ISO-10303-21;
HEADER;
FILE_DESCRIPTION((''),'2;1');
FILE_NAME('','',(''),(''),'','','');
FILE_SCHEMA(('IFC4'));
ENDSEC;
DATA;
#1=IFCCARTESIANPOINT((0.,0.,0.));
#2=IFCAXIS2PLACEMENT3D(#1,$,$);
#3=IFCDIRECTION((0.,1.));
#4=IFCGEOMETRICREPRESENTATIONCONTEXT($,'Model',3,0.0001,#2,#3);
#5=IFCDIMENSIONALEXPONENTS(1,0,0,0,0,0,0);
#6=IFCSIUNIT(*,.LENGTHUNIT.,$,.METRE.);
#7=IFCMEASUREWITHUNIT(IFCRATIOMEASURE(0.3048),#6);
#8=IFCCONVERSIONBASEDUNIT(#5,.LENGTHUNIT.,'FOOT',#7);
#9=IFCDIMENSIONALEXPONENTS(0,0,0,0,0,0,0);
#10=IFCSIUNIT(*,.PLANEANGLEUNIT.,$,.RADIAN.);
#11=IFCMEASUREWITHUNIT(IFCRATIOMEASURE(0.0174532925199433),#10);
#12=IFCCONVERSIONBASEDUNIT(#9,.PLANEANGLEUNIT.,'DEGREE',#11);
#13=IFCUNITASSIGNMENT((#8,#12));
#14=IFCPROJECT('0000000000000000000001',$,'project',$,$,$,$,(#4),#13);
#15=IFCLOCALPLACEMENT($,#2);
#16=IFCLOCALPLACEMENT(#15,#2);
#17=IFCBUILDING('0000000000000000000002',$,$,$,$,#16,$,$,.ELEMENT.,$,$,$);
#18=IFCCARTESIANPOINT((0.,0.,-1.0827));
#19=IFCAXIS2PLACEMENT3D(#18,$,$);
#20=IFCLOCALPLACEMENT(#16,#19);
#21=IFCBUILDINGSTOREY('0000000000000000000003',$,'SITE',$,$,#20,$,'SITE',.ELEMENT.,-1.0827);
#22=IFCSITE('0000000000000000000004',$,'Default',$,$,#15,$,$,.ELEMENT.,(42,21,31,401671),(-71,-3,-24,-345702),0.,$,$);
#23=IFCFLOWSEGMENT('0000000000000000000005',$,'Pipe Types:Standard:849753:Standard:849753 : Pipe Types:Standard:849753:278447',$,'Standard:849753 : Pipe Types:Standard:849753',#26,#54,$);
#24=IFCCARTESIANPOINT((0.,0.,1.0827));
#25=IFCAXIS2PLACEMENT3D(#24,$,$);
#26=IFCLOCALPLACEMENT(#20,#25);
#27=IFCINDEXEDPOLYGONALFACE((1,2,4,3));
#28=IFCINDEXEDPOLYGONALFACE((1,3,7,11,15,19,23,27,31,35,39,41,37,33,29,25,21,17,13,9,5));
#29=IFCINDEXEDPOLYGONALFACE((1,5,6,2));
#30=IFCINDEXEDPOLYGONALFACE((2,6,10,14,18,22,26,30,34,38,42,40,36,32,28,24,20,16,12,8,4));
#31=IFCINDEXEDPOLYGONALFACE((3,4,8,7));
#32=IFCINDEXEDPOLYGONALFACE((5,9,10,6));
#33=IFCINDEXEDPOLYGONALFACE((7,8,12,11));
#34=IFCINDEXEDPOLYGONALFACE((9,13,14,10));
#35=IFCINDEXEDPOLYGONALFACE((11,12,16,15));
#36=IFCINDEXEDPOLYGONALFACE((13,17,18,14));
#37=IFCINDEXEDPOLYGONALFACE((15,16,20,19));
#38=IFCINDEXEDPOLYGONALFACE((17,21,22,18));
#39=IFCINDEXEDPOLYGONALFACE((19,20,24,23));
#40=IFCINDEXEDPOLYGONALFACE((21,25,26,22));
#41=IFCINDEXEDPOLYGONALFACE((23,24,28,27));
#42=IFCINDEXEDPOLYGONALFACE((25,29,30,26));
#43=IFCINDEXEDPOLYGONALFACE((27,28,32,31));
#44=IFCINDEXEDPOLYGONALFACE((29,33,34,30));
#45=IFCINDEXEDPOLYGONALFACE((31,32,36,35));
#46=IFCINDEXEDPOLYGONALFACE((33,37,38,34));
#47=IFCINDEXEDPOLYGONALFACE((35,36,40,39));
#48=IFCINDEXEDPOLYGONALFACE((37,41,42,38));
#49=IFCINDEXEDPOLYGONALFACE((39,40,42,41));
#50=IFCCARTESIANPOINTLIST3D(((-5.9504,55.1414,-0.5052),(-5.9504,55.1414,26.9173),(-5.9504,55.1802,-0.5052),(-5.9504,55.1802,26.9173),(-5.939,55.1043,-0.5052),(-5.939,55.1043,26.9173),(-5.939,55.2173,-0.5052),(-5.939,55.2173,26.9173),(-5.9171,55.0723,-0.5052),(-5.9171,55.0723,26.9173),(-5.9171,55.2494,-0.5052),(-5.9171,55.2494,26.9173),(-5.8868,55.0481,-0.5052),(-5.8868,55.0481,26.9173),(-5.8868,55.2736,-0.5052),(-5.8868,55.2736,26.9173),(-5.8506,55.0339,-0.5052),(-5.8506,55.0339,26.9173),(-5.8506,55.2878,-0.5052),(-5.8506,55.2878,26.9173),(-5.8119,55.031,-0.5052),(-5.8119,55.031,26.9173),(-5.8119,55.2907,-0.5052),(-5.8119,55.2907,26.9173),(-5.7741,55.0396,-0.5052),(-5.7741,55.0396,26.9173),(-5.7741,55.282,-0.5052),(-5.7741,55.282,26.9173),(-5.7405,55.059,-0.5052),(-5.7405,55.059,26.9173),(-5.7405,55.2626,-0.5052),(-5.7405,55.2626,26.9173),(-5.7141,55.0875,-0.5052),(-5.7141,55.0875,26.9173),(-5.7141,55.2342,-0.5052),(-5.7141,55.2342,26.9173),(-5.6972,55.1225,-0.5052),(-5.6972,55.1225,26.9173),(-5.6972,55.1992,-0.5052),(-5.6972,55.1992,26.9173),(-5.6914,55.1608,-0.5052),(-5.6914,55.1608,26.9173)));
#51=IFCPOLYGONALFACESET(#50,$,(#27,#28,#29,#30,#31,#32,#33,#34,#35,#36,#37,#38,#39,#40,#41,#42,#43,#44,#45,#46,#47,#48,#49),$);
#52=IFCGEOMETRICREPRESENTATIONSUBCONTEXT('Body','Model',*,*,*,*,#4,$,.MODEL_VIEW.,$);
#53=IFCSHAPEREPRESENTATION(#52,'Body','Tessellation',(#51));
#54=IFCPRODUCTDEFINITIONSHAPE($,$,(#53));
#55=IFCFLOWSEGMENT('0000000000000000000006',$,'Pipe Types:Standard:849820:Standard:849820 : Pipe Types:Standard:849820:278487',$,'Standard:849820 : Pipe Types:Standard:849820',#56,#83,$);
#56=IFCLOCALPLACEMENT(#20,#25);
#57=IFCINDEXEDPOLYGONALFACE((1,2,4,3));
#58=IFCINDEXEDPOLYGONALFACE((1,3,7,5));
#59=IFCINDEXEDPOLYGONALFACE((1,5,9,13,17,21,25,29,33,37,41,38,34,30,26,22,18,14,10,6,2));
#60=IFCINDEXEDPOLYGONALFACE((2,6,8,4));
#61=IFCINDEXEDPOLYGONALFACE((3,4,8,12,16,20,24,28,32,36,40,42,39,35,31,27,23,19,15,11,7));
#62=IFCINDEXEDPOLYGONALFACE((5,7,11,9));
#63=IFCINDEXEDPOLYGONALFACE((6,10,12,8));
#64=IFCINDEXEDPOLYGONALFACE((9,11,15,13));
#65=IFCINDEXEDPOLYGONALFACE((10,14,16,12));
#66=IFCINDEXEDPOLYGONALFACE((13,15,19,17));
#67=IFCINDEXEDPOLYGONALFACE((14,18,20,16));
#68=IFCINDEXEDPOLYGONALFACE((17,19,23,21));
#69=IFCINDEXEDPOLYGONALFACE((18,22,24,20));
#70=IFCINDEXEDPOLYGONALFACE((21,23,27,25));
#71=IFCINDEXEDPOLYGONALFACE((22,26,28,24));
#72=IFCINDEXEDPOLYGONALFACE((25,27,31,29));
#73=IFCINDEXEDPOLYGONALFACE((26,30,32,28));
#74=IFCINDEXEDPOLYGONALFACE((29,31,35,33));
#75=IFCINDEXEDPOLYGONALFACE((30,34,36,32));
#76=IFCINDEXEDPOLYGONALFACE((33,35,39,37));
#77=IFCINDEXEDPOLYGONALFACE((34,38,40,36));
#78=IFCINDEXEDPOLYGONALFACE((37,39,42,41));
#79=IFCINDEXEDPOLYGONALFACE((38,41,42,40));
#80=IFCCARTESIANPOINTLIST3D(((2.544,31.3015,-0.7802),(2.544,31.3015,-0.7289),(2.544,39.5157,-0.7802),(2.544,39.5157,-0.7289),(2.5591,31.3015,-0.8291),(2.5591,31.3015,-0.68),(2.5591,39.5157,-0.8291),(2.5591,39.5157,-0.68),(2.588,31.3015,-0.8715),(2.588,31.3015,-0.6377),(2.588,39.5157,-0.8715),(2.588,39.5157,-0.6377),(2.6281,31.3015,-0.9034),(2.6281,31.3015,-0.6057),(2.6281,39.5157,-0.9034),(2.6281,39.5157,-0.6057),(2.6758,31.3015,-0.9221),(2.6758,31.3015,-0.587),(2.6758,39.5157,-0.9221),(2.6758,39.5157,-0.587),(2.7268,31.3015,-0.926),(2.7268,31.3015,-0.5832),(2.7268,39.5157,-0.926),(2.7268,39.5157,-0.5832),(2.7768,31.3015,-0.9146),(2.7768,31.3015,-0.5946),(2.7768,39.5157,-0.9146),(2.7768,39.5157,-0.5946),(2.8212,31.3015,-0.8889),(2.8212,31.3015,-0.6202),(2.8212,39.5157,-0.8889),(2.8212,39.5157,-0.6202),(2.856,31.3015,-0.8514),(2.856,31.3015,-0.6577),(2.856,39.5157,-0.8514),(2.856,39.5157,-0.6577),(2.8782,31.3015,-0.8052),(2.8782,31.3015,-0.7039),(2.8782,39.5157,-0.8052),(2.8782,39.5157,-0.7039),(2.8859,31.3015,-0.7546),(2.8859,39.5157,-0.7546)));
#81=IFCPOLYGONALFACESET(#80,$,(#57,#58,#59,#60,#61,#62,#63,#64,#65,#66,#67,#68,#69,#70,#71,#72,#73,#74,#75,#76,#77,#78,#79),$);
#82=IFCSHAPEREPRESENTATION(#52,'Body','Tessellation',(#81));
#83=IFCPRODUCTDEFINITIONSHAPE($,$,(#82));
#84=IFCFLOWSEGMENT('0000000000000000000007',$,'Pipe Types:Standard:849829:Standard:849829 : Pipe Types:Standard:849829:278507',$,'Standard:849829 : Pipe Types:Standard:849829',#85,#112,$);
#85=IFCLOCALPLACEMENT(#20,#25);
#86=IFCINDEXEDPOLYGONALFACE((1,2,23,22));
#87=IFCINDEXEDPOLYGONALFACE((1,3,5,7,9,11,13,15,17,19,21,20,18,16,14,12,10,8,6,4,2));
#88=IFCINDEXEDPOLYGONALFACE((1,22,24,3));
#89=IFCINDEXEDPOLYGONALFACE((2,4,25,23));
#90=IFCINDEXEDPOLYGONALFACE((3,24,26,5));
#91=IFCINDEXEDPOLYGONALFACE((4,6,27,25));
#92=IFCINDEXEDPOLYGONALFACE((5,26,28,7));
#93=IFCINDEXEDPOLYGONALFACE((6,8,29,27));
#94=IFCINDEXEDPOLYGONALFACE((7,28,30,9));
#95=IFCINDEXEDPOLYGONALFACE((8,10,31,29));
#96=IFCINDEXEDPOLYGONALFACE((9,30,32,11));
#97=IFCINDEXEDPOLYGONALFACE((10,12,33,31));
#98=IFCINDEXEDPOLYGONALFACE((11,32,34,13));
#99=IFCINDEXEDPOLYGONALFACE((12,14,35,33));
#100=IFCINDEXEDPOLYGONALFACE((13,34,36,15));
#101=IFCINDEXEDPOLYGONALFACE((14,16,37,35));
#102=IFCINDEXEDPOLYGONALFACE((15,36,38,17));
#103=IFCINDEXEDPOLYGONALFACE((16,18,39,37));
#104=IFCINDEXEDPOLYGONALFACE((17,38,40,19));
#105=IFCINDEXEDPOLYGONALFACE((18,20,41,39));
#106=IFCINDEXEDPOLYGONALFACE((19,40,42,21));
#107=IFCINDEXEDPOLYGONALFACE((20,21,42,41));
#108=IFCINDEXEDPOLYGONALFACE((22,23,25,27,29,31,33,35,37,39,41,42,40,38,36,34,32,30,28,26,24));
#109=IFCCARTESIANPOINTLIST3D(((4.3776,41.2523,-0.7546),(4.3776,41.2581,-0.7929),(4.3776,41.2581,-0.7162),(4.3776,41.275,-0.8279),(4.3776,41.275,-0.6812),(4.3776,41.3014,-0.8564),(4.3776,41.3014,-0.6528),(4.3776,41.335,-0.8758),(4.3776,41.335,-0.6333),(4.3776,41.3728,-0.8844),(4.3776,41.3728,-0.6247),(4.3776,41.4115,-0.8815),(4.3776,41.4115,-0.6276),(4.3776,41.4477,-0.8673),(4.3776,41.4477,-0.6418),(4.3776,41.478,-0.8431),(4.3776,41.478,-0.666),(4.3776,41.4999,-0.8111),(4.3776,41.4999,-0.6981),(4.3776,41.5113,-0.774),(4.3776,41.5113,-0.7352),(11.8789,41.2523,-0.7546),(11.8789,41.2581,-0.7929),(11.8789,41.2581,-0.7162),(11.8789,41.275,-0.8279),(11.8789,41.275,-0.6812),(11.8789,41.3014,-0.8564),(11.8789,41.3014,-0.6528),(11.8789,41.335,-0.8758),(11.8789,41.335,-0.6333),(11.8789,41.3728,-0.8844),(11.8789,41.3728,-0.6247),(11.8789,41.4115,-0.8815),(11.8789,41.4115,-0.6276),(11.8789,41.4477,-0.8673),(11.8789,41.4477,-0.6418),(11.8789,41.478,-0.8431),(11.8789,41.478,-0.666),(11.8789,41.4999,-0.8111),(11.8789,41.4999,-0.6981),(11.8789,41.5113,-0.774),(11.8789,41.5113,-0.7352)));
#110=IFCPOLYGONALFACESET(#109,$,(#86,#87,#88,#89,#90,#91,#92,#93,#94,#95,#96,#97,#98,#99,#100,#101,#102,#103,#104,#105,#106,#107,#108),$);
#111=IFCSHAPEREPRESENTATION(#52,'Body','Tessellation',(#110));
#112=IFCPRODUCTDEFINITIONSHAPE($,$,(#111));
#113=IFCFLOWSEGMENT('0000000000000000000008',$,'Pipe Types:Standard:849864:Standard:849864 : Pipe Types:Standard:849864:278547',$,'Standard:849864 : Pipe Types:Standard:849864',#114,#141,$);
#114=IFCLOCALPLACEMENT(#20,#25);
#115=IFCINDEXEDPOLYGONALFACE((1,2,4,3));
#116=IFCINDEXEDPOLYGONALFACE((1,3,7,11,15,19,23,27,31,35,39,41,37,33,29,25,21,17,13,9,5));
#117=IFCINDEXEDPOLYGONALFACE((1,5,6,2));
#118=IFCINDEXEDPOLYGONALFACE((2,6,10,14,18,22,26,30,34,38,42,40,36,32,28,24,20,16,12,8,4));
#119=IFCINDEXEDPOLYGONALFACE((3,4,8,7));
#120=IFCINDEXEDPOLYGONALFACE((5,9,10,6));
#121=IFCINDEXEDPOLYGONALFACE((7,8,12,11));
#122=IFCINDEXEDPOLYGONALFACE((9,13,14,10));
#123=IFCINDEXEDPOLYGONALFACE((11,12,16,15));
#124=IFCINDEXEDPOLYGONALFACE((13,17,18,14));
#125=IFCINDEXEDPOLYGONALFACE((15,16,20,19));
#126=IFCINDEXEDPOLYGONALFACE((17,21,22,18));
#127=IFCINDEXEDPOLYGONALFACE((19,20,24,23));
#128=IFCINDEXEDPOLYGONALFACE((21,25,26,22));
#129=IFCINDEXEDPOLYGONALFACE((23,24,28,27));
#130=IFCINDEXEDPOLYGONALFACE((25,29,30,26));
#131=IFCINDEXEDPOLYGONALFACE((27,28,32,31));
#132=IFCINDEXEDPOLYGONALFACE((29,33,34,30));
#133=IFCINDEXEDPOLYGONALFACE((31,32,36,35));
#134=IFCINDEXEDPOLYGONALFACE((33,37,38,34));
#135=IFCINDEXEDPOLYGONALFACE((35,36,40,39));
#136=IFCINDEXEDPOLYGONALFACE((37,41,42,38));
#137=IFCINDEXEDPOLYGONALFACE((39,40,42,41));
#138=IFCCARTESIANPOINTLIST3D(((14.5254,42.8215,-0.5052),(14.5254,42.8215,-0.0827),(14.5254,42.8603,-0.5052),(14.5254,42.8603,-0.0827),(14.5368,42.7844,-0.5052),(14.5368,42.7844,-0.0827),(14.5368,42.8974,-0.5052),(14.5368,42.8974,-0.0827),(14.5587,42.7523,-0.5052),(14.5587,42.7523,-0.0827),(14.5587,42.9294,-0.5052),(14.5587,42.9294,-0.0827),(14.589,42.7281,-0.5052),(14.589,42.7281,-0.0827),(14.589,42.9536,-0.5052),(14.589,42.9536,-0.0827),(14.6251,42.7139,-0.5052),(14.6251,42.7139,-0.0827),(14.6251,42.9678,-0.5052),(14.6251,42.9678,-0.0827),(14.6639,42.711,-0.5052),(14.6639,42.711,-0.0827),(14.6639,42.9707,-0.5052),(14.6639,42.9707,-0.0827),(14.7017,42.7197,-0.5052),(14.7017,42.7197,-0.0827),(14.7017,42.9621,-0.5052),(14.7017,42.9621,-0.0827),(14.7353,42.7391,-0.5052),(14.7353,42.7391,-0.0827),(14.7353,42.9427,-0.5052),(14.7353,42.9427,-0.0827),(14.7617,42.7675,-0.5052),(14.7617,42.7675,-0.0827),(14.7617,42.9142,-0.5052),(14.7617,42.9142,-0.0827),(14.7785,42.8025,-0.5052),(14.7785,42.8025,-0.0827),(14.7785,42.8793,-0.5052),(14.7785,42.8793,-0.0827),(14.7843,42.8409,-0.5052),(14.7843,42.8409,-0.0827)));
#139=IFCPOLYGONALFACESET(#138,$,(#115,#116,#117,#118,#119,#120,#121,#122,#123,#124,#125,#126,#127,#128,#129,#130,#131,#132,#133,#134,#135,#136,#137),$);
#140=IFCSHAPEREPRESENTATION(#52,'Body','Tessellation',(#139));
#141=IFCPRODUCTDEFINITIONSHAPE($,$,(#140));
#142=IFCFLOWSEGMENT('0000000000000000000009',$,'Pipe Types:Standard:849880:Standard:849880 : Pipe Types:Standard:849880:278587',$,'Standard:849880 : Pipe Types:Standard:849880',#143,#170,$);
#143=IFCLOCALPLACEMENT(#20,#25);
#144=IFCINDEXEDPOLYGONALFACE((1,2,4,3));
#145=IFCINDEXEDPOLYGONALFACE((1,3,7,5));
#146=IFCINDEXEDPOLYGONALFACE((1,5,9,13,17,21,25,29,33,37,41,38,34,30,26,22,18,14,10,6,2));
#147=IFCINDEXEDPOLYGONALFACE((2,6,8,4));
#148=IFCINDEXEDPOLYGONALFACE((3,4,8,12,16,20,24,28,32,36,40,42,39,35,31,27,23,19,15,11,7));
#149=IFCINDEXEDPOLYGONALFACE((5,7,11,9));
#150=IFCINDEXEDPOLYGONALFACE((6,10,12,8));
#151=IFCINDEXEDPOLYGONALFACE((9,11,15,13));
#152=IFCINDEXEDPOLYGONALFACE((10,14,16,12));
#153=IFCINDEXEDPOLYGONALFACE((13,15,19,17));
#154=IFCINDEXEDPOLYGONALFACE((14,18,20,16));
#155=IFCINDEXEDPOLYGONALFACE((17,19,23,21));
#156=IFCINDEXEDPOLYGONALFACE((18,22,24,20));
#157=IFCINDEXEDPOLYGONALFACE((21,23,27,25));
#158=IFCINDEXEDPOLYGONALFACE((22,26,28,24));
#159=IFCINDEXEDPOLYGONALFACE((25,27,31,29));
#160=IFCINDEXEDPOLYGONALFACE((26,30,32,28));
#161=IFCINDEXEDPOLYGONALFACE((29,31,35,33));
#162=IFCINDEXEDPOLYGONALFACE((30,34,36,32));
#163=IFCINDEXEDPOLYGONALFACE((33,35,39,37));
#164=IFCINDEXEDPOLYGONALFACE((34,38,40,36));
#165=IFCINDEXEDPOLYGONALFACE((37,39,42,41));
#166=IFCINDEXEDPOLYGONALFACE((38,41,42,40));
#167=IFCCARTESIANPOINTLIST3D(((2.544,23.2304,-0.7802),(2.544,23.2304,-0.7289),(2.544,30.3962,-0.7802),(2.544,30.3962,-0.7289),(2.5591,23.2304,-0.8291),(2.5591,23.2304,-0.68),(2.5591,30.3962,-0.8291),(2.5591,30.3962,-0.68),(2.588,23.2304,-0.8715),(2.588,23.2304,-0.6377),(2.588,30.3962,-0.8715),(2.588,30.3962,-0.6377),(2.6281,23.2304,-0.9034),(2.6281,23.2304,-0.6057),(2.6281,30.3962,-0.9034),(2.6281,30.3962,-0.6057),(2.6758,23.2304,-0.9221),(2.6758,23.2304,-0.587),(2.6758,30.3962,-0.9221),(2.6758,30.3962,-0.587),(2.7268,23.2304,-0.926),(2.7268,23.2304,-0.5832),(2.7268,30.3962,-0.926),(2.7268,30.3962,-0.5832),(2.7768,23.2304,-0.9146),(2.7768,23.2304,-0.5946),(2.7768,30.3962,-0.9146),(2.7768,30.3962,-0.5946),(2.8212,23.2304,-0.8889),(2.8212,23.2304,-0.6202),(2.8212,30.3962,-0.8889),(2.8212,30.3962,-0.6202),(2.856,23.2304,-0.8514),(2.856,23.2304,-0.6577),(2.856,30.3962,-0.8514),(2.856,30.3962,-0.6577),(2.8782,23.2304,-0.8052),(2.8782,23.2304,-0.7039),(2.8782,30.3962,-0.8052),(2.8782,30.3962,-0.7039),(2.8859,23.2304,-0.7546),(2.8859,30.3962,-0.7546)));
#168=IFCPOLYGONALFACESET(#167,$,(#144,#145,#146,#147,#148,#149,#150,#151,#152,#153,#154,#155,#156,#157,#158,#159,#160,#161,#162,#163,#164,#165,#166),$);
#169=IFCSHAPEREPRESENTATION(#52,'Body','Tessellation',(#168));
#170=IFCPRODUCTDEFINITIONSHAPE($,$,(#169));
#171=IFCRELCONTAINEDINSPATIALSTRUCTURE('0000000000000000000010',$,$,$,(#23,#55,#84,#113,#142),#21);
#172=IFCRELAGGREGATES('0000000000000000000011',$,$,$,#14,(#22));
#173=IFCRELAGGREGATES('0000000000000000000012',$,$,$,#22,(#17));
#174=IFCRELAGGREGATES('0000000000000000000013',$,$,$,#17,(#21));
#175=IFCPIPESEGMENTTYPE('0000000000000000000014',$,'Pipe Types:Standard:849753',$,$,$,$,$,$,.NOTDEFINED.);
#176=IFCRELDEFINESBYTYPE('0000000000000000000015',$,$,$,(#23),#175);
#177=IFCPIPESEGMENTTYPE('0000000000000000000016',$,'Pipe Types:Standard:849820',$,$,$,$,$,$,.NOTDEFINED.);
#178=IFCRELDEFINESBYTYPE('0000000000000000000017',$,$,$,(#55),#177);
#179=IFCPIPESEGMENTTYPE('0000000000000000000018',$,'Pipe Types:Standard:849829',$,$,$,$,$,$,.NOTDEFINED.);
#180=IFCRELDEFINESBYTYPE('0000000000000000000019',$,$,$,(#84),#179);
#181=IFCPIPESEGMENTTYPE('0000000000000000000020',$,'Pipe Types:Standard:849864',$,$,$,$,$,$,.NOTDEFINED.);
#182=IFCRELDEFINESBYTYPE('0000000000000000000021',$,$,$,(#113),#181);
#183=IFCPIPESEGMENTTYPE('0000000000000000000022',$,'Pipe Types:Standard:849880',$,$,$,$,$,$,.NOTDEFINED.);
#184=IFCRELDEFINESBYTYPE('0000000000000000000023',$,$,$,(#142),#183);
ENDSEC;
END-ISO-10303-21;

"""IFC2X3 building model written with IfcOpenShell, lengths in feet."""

from ifc_helpers import new_model, entity, si_unit, converted_unit, direction, frame, frame_2d, origin, origin_2d_with_axis, place, context, subcontext, project, spatial, circle, extrude, source, transform, mapped, type_object, type_shapes, element, save


model = new_model("IFC2X3")

# Units and contexts
model_context = context("Model", 3, precision=0.0001, world=origin(), true_north=direction((0.0, 1.0)))
body_context = subcontext(model_context, "Body", "Model", "MODEL_VIEW")
ifc_project = project(units=[converted_unit("LENGTHUNIT", "FOOT", entity("IfcRatioMeasure", 0.3048), si_unit("LENGTHUNIT", "METRE"), dimensions=[1, 0, 0, 0, 0, 0, 0]), converted_unit("PLANEANGLEUNIT", "DEGREE", entity("IfcRatioMeasure", 0.0174532925199433), si_unit("PLANEANGLEUNIT", "RADIAN"), dimensions=[0, 0, 0, 0, 0, 0, 0])], contexts=[model_context])

# Site, building, storey
site_placement = place(None, origin())
site = spatial("IfcSite", under=ifc_project, at=site_placement, Name="Default", CompositionType="ELEMENT", RefLatitude=(42, 21, 31, 401671), RefLongitude=(-71, -3, -24, -345702), RefElevation=0.0)
building_placement = place(site_placement, origin())
building = spatial("IfcBuilding", under=site, at=building_placement, CompositionType="ELEMENT")
storey_placement = place(building_placement, frame((0.0, 0.0, -1.0827)))
storey = spatial("IfcBuildingStorey", under=building, at=storey_placement, Name="SITE", LongName="SITE", CompositionType="ELEMENT", Elevation=-1.0827)

# Flow segments
pipe_segment_type_1 = type_object("IfcPipeSegmentType", Name="Pipe Types:Standard:849753", PredefinedType="NOTDEFINED")
shared_shape_1 = source(origin(), body_context, "Body", "SweptSolid", [
    extrude(circle(Radius=0.1302, at=origin_2d_with_axis()), frame((-5.8217, 55.1608, -0.5052)), (0.0, 0.0, 1.0), 27.4225),
])
type_shapes(pipe_segment_type_1, [shared_shape_1])
flow_segment_1_placement = place(storey_placement, frame((0.0, 0.0, 1.0827)))
element("IfcFlowSegment", 1, at=flow_segment_1_placement, inside=storey, type_object=pipe_segment_type_1, Name="Pipe Types:Standard:849753:Standard:849753 : Pipe Types:Standard:849753:278447", ObjectType="Standard:849753 : Pipe Types:Standard:849753", context=body_context, shape_type="MappedRepresentation", body=[
    mapped(shared_shape_1, transform((0.0, 0.0, 0.0), scale=1.0)),
])
pipe_segment_type_2 = type_object("IfcPipeSegmentType", Name="Pipe Types:Standard:849820", PredefinedType="NOTDEFINED")
shared_shape_2 = source(origin(), body_context, "Body", "SweptSolid", [
    extrude(circle(Radius=0.1719, at=frame_2d((0.0, 0.0), x_axis=(1.0, 0.0))), frame((2.714, 31.3015, -0.7546), z_axis=(0.0, 1.0, 0.0), x_axis=(1.0, 0.0, 0.0)), (0.0, 0.0, 1.0), 8.2142),
])
type_shapes(pipe_segment_type_2, [shared_shape_2])
flow_segment_2_placement = place(storey_placement, frame((0.0, 0.0, 1.0827)))
element("IfcFlowSegment", 2, at=flow_segment_2_placement, inside=storey, type_object=pipe_segment_type_2, Name="Pipe Types:Standard:849820:Standard:849820 : Pipe Types:Standard:849820:278487", ObjectType="Standard:849820 : Pipe Types:Standard:849820", context=body_context, shape_type="MappedRepresentation", body=[
    mapped(shared_shape_2, transform((0.0, 0.0, 0.0), scale=1.0)),
])
pipe_segment_type_3 = type_object("IfcPipeSegmentType", Name="Pipe Types:Standard:849829", PredefinedType="NOTDEFINED")
shared_shape_3 = source(origin(), body_context, "Body", "SweptSolid", [
    extrude(circle(Radius=0.1302, at=frame_2d((0.0, 0.0), x_axis=(1.0, 0.0))), frame((4.3776, 41.3825, -0.7546), z_axis=(1.0, 0.0, 0.0), x_axis=(0.0, -1.0, 0.0)), (0.0, 0.0, 1.0), 7.5013),
])
type_shapes(pipe_segment_type_3, [shared_shape_3])
flow_segment_3_placement = place(storey_placement, frame((0.0, 0.0, 1.0827)))
element("IfcFlowSegment", 3, at=flow_segment_3_placement, inside=storey, type_object=pipe_segment_type_3, Name="Pipe Types:Standard:849829:Standard:849829 : Pipe Types:Standard:849829:278507", ObjectType="Standard:849829 : Pipe Types:Standard:849829", context=body_context, shape_type="MappedRepresentation", body=[
    mapped(shared_shape_3, transform((0.0, 0.0, 0.0), scale=1.0)),
])
pipe_segment_type_4 = type_object("IfcPipeSegmentType", Name="Pipe Types:Standard:849864", PredefinedType="NOTDEFINED")
shared_shape_4 = source(origin(), body_context, "Body", "SweptSolid", [
    extrude(circle(Radius=0.1302, at=origin_2d_with_axis()), frame((14.6541, 42.8409, -0.5052)), (0.0, 0.0, 1.0), 0.4225),
])
type_shapes(pipe_segment_type_4, [shared_shape_4])
flow_segment_4_placement = place(storey_placement, frame((0.0, 0.0, 1.0827)))
element("IfcFlowSegment", 4, at=flow_segment_4_placement, inside=storey, type_object=pipe_segment_type_4, Name="Pipe Types:Standard:849864:Standard:849864 : Pipe Types:Standard:849864:278547", ObjectType="Standard:849864 : Pipe Types:Standard:849864", context=body_context, shape_type="MappedRepresentation", body=[
    mapped(shared_shape_4, transform((0.0, 0.0, 0.0), scale=1.0)),
])
pipe_segment_type_5 = type_object("IfcPipeSegmentType", Name="Pipe Types:Standard:849880", PredefinedType="NOTDEFINED")
shared_shape_5 = source(origin(), body_context, "Body", "SweptSolid", [
    extrude(circle(Radius=0.1719, at=frame_2d((0.0, 0.0), x_axis=(1.0, 0.0))), frame((2.714, 23.2304, -0.7546), z_axis=(0.0, 1.0, 0.0), x_axis=(1.0, 0.0, 0.0)), (0.0, 0.0, 1.0), 7.1658),
])
type_shapes(pipe_segment_type_5, [shared_shape_5])
flow_segment_5_placement = place(storey_placement, frame((0.0, 0.0, 1.0827)))
element("IfcFlowSegment", 5, at=flow_segment_5_placement, inside=storey, type_object=pipe_segment_type_5, Name="Pipe Types:Standard:849880:Standard:849880 : Pipe Types:Standard:849880:278587", ObjectType="Standard:849880 : Pipe Types:Standard:849880", context=body_context, shape_type="MappedRepresentation", body=[
    mapped(shared_shape_5, transform((0.0, 0.0, 0.0), scale=1.0)),
])

save(model, "model.ifc")
